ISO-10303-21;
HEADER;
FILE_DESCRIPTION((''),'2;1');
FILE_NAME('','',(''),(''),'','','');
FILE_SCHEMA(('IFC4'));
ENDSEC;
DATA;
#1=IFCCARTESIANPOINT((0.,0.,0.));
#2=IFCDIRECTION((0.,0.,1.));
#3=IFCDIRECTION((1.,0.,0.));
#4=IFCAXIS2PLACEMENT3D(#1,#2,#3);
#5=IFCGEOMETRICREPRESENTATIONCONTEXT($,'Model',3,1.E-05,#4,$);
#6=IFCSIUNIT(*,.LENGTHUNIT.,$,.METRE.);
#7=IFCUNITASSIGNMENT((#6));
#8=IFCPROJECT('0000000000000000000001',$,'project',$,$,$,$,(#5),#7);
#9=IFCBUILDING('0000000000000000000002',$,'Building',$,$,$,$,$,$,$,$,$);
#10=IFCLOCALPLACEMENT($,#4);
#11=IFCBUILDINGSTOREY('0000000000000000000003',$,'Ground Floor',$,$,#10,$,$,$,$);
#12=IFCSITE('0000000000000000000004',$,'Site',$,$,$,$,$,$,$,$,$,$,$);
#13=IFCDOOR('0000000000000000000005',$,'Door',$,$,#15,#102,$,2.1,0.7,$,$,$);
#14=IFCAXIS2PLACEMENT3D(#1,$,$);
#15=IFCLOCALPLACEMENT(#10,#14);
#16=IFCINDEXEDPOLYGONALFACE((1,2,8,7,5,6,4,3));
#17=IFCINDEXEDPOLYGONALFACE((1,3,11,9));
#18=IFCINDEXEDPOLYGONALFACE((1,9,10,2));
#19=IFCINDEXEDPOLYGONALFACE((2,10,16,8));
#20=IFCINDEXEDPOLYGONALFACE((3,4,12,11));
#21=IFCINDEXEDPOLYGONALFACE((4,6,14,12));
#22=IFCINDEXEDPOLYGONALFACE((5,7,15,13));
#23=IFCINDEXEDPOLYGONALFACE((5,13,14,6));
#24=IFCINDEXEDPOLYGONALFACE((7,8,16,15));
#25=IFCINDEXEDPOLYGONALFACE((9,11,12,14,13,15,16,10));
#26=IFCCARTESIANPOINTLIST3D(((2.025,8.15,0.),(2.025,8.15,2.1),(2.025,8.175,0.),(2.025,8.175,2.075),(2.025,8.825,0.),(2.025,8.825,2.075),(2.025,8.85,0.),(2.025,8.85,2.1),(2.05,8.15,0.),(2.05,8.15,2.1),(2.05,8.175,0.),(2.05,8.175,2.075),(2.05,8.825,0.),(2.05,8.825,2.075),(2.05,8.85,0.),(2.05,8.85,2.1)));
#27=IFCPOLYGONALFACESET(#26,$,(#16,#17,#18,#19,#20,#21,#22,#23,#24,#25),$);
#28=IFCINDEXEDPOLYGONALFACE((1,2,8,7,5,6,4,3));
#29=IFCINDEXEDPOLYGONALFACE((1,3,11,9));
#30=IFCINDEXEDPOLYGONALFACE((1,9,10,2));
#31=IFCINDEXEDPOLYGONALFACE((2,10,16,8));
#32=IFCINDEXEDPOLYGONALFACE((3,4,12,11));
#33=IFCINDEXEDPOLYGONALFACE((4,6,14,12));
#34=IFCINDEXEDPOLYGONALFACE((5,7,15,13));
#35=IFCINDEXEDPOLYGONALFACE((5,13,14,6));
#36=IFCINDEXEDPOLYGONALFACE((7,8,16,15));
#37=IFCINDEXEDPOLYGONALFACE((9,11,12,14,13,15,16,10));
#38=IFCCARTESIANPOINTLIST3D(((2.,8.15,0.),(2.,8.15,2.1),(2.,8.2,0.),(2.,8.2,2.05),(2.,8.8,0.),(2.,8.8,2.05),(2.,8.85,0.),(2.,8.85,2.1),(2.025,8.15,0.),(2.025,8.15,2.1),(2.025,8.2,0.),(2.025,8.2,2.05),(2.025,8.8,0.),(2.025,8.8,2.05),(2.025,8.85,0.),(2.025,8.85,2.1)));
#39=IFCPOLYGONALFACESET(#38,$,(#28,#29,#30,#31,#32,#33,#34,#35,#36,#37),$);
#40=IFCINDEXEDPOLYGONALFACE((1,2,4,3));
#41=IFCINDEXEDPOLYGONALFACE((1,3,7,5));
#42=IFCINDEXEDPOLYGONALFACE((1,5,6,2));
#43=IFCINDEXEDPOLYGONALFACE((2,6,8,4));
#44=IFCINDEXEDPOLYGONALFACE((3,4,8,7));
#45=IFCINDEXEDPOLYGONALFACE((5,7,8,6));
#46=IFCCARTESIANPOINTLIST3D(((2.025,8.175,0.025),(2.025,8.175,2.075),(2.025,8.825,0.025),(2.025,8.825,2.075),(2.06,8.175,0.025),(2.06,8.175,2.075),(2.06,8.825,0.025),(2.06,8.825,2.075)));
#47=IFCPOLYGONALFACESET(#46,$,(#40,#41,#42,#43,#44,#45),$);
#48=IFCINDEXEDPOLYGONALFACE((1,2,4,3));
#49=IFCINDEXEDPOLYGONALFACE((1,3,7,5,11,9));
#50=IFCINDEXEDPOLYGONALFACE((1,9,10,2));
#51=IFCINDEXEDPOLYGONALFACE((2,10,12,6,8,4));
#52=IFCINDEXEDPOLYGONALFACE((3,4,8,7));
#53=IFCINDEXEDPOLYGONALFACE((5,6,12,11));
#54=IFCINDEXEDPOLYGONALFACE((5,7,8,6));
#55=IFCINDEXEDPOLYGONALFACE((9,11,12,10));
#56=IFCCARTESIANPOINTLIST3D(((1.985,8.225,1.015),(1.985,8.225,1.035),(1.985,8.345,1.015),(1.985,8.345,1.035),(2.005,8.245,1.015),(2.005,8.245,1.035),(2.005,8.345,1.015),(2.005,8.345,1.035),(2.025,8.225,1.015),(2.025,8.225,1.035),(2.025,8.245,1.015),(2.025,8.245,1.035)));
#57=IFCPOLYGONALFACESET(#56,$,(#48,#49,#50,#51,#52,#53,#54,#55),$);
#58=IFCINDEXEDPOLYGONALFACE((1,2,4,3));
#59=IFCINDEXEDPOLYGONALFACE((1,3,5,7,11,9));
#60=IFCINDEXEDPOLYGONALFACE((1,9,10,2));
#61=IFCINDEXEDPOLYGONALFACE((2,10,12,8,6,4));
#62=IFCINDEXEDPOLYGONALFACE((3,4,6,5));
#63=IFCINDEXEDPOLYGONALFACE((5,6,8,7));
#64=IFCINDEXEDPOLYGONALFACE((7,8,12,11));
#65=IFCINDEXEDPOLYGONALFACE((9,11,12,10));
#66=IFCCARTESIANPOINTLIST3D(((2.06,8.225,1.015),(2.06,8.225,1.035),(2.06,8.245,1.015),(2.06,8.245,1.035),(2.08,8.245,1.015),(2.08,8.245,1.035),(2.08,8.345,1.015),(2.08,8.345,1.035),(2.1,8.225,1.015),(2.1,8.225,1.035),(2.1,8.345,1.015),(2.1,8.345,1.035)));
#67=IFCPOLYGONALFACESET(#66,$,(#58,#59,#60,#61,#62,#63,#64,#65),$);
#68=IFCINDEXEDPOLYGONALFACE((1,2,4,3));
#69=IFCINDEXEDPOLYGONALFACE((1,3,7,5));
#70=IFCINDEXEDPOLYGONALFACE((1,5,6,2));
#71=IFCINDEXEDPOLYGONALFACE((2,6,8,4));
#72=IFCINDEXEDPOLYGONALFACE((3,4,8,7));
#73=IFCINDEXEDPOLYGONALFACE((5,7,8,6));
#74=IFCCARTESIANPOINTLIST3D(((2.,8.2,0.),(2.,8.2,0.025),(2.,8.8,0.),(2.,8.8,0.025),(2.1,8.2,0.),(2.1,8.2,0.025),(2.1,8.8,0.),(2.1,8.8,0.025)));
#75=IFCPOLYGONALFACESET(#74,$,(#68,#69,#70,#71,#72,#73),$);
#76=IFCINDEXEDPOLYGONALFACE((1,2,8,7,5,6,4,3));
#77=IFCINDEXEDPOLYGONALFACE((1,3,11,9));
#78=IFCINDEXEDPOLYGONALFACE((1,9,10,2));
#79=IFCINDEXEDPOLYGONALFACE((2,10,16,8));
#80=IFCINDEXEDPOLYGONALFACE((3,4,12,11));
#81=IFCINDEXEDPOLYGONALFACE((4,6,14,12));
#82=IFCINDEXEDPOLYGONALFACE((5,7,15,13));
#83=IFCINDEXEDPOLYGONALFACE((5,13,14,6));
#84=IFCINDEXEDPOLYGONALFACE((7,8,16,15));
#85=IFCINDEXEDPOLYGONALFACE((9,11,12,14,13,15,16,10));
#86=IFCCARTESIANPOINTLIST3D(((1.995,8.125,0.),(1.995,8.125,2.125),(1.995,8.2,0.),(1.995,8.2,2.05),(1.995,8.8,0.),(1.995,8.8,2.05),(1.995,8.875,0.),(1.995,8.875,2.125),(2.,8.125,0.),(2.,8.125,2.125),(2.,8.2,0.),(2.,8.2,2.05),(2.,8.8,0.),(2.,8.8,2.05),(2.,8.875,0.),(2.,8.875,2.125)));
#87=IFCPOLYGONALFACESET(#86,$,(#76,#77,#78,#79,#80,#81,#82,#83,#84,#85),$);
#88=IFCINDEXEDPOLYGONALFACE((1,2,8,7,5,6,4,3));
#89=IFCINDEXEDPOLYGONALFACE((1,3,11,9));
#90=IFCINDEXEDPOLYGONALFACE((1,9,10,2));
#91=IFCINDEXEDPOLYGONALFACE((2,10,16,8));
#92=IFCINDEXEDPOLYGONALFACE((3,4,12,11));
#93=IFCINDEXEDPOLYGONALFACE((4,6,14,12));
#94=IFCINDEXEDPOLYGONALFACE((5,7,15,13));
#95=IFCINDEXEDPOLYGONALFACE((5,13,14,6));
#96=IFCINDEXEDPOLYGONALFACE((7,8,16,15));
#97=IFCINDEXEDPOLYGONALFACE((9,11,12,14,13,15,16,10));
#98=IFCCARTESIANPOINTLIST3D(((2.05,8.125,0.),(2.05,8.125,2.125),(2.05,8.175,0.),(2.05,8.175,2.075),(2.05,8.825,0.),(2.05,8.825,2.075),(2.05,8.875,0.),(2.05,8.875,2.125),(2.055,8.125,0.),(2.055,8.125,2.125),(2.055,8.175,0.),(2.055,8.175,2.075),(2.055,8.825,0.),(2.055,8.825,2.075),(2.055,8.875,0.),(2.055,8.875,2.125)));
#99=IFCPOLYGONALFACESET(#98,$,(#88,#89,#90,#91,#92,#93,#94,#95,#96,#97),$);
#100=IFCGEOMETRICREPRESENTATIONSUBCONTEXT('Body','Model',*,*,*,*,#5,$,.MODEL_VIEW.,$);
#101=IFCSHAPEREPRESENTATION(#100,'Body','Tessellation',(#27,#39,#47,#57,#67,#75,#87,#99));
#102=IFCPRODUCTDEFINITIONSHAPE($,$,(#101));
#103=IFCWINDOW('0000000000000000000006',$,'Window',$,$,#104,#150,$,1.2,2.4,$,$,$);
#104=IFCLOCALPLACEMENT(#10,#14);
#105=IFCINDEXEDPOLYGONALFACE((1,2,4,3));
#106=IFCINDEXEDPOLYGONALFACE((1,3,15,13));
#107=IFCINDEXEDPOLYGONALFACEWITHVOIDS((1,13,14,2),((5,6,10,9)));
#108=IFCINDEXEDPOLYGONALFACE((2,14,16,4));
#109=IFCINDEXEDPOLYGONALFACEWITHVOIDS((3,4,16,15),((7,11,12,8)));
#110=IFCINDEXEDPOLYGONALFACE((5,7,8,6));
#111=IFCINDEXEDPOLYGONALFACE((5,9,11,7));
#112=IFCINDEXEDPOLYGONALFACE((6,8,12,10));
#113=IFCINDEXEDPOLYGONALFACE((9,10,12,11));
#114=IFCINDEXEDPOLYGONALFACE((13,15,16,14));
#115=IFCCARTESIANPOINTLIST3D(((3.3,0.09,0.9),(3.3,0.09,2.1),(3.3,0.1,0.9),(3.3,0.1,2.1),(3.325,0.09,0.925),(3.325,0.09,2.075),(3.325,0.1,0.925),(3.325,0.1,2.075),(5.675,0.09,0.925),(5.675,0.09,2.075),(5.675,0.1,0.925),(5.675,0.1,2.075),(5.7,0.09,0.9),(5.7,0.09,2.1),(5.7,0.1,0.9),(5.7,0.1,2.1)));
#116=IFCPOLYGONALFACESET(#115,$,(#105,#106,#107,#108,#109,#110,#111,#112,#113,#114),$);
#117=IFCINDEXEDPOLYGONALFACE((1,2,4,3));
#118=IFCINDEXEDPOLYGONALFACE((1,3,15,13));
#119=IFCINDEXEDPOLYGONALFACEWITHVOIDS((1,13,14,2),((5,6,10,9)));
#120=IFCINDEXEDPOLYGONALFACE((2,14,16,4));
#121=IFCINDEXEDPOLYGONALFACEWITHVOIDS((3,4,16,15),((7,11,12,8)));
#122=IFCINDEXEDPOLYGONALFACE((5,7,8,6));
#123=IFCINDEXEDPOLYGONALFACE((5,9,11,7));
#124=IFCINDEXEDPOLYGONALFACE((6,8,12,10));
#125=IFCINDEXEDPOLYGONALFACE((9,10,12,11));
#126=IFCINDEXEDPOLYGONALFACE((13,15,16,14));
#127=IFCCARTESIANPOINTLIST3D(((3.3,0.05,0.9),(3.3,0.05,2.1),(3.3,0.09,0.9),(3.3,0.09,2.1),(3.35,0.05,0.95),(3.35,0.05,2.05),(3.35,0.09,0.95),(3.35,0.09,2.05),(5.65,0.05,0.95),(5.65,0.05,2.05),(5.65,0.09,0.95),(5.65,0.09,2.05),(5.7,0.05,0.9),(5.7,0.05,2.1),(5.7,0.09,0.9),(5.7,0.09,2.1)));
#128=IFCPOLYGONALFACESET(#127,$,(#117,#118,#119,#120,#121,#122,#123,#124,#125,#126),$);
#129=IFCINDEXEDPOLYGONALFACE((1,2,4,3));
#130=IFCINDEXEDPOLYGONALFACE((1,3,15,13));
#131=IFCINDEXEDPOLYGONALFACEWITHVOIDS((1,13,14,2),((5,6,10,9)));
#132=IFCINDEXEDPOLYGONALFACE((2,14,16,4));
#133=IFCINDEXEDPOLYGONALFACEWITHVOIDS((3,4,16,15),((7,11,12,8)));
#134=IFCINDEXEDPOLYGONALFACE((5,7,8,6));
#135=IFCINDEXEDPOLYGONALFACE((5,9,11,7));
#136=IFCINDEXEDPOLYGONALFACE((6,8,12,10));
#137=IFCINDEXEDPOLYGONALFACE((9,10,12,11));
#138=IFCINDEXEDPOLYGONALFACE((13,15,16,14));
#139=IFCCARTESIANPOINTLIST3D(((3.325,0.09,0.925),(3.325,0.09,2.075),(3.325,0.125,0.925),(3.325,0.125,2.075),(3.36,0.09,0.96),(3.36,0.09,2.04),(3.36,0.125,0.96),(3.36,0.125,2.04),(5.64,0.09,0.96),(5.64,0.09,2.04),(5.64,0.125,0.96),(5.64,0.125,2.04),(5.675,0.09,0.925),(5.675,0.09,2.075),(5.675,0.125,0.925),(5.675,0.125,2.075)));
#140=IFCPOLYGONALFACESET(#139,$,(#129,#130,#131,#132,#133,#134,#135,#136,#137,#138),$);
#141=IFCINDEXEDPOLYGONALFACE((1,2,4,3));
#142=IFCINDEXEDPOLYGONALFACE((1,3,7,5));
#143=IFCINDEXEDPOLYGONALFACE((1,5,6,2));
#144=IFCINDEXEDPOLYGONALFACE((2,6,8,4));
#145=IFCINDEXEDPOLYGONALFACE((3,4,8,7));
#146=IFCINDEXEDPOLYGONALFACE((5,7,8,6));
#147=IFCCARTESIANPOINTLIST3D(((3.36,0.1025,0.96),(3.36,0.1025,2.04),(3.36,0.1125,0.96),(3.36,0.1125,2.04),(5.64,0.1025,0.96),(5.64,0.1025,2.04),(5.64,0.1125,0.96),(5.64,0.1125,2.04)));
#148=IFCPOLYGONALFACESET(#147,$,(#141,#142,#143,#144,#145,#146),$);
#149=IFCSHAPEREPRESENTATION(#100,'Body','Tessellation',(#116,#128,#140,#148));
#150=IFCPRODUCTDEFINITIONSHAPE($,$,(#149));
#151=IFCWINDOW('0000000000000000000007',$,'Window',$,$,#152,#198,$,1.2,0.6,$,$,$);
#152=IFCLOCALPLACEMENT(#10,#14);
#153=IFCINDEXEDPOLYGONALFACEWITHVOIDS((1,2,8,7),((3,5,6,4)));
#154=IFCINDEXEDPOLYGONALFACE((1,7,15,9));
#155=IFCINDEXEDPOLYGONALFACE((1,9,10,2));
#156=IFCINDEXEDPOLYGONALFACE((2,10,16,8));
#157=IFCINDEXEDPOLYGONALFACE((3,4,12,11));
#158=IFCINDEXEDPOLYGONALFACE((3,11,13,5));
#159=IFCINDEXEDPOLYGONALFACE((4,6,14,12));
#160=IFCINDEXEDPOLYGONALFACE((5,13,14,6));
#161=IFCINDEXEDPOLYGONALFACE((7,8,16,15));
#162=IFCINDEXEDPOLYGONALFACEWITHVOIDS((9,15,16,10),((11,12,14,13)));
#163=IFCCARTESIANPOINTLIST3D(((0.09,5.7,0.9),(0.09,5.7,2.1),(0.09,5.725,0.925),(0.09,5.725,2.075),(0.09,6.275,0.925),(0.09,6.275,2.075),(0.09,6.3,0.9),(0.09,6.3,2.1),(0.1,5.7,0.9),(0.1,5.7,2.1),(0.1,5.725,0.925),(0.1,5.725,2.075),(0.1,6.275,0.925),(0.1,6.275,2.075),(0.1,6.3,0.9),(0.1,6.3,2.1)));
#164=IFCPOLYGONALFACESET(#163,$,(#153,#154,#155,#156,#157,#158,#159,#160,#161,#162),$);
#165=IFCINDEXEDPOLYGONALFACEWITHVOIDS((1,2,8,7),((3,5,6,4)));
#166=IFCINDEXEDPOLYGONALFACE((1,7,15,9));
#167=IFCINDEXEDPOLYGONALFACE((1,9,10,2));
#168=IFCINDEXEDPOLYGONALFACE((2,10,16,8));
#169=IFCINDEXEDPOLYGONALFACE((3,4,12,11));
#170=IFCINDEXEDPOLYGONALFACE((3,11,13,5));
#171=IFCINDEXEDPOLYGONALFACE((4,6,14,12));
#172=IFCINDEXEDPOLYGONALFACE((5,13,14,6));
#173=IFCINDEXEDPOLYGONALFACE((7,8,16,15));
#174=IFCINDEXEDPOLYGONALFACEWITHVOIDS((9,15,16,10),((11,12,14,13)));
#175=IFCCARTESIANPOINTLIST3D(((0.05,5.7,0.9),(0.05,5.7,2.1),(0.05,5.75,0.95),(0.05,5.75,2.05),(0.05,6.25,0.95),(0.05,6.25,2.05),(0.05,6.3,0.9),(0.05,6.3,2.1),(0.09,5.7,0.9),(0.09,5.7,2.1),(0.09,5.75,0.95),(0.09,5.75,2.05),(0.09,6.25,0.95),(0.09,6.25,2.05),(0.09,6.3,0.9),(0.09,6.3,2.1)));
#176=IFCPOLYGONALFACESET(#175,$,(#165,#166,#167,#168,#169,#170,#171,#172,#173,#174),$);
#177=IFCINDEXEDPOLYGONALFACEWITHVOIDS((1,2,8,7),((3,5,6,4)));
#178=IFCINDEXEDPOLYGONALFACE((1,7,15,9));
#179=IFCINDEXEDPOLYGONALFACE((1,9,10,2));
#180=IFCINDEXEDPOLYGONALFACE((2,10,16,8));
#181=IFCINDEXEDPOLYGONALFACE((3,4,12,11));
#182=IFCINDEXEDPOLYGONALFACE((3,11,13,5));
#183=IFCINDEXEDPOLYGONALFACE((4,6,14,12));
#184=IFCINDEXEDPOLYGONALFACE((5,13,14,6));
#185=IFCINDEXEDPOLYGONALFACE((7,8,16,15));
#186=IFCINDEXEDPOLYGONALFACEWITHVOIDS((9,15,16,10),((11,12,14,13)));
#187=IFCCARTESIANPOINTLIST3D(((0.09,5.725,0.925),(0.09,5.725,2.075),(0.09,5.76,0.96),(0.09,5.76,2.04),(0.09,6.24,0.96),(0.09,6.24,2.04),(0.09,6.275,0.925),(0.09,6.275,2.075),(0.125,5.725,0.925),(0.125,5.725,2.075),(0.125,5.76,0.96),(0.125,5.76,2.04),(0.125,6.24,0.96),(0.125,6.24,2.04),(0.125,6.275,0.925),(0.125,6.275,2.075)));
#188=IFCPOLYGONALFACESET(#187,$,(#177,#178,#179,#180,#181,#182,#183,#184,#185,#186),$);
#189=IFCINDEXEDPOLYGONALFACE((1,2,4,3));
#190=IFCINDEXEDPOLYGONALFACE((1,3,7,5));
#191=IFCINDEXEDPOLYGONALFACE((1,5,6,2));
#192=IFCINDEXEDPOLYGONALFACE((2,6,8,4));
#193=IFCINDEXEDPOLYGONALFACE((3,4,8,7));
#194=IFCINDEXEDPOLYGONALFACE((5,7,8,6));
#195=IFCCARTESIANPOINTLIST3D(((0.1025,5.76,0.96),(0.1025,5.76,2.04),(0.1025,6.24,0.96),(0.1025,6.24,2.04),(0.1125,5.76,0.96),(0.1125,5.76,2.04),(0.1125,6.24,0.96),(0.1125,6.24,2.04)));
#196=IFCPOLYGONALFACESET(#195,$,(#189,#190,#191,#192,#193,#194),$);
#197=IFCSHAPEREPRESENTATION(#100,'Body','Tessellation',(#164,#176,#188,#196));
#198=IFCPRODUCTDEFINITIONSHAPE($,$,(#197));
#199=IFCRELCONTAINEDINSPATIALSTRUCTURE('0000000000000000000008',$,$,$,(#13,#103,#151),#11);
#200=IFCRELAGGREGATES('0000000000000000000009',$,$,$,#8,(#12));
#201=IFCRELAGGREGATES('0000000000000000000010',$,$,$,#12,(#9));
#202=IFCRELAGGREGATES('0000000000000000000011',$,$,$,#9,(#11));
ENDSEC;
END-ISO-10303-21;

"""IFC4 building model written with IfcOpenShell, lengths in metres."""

from ifc_helpers import new_model, si_unit, frame, origin_with_axes, place, context, subcontext, project, spatial, line, indexed_curve, outline, extrude, element, save


model = new_model("IFC4")

# Units and contexts
model_context = context("Model", 3, precision=1e-05, world=origin_with_axes())
body_context = subcontext(model_context, "Body", "Model", "MODEL_VIEW")
ifc_project = project(units=[si_unit("LENGTHUNIT", "METRE")], contexts=[model_context])

# Site, building, storey
site = spatial("IfcSite", under=ifc_project, Name="Site")
building = spatial("IfcBuilding", under=site, Name="Building")
storey_placement = place(None, origin_with_axes())
storey = spatial("IfcBuildingStorey", under=building, at=storey_placement, Name="Ground Floor")

# Door
door_1_placement = place(storey_placement, frame((2.0, 8.85, 0.0), z_axis=(0.0, 0.0, 1.0), x_axis=(0.0, -1.0, 0.0)))
element("IfcDoor", 1, at=door_1_placement, inside=storey, Name="Door", OverallHeight=2.1, OverallWidth=0.7, context=body_context, shape_type="SweptSolid", body=[
    extrude(outline(indexed_curve([(0.0, 0.0), (0.0, 2.1), (0.7, 2.1), (0.7, 0.0), (0.675, 0.0), (0.675, 2.075), (0.025, 2.075), (0.025, 0.0)], segments=[line(1, 2, 3, 4, 5, 6, 7, 8, 1)])), frame((0.0, 0.025, 0.0), z_axis=(0.0, -1.0, 0.0), x_axis=(1.0, 0.0, 0.0)), (0.0, 0.0, -1.0), 0.025),
    extrude(outline(indexed_curve([(0.0, 0.0), (0.0, 2.1), (0.7, 2.1), (0.7, 0.0), (0.65, 0.0), (0.65, 2.05), (0.05, 2.05), (0.05, 0.0)], segments=[line(1, 2, 3, 4, 5, 6, 7, 8, 1)])), frame((0.0, 0.0, 0.0), z_axis=(0.0, -1.0, 0.0), x_axis=(1.0, 0.0, 0.0)), (0.0, 0.0, -1.0), 0.025),
    extrude(outline(indexed_curve([(0.0, 0.0), (0.65, 0.0), (0.65, 0.035), (0.0, 0.035)], segments=[line(1, 2, 3, 4, 1)])), frame((0.025, 0.025, 0.025), z_axis=(0.0, 0.0, 1.0), x_axis=(1.0, 0.0, 0.0)), (0.0, 0.0, 1.0), 2.05),
    extrude(outline(indexed_curve([(0.0, 0.0), (0.0, -0.04), (-0.12, -0.04), (-0.12, -0.02), (-0.02, -0.02), (-0.02, 0.0)], segments=[line(1, 2, 3, 4, 5, 6, 1)])), frame((0.625, 0.025, 1.015), z_axis=(0.0, 0.0, 1.0), x_axis=(1.0, 0.0, 0.0)), (0.0, 0.0, 1.0), 0.02),
    extrude(outline(indexed_curve([(0.0, 0.0), (0.0, 0.04), (-0.12, 0.04), (-0.12, 0.02), (-0.02, 0.02), (-0.02, 0.0)], segments=[line(1, 2, 3, 4, 5, 6, 1)])), frame((0.625, 0.06, 1.015), z_axis=(0.0, 0.0, 1.0), x_axis=(1.0, 0.0, 0.0)), (0.0, 0.0, 1.0), 0.02),
    extrude(outline(indexed_curve([(0.0, 0.0), (0.6, 0.0), (0.6, 0.1), (0.0, 0.1)], segments=[line(1, 2, 3, 4, 1)])), frame((0.05, 0.0, 0.0), z_axis=(0.0, 0.0, 1.0), x_axis=(1.0, 0.0, 0.0)), (0.0, 0.0, 1.0), 0.025),
    extrude(outline(indexed_curve([(0.0, 0.0), (0.0, 2.125), (0.75, 2.125), (0.75, 0.0), (0.675, 0.0), (0.675, 2.05), (0.075, 2.05), (0.075, 0.0)], segments=[line(1, 2, 3, 4, 5, 6, 7, 8, 1)])), frame((-0.025, -0.005, 0.0), z_axis=(0.0, -1.0, 0.0), x_axis=(1.0, 0.0, 0.0)), (0.0, 0.0, -1.0), 0.005),
    extrude(outline(indexed_curve([(0.0, 0.0), (0.0, 2.125), (0.75, 2.125), (0.75, 0.0), (0.7, 0.0), (0.7, 2.075), (0.05, 2.075), (0.05, 0.0)], segments=[line(1, 2, 3, 4, 5, 6, 7, 8, 1)])), frame((-0.025, 0.05, 0.0), z_axis=(0.0, -1.0, 0.0), x_axis=(1.0, 0.0, 0.0)), (0.0, 0.0, -1.0), 0.005),
])

# Windows
window_1_placement = place(storey_placement, frame((3.3, 0.0, 0.9), z_axis=(0.0, 0.0, 1.0), x_axis=(1.0, 0.0, 0.0)))
element("IfcWindow", 2, at=window_1_placement, inside=storey, Name="Window", OverallHeight=1.2, OverallWidth=2.4, context=body_context, shape_type="SweptSolid", body=[
    extrude(outline(indexed_curve([(0.0, 0.0), (2.4, 0.0), (2.4, 1.2), (0.0, 1.2)], segments=[line(1, 2, 3, 4, 1)]), holes=[indexed_curve([(0.025, 0.025), (2.375, 0.025), (2.375, 1.175), (0.025, 1.175)], segments=[line(1, 2, 3, 4, 1)])]), frame((0.0, 0.09, 0.0), z_axis=(0.0, -1.0, 0.0), x_axis=(1.0, 0.0, 0.0)), (0.0, 0.0, -1.0), 0.01),
    extrude(outline(indexed_curve([(0.0, 0.0), (2.4, 0.0), (2.4, 1.2), (0.0, 1.2)], segments=[line(1, 2, 3, 4, 1)]), holes=[indexed_curve([(0.05, 0.05), (2.35, 0.05), (2.35, 1.15), (0.05, 1.15)], segments=[line(1, 2, 3, 4, 1)])]), frame((0.0, 0.05, 0.0), z_axis=(0.0, -1.0, 0.0), x_axis=(1.0, 0.0, 0.0)), (0.0, 0.0, -1.0), 0.04),
    extrude(outline(indexed_curve([(0.0, 0.0), (2.35, 0.0), (2.35, 1.15), (0.0, 1.15)], segments=[line(1, 2, 3, 4, 1)]), holes=[indexed_curve([(0.035, 0.035), (2.315, 0.035), (2.315, 1.115), (0.035, 1.115)], segments=[line(1, 2, 3, 4, 1)])]), frame((0.025, 0.09, 0.025), z_axis=(0.0, -1.0, 0.0), x_axis=(1.0, 0.0, 0.0)), (0.0, 0.0, -1.0), 0.035),
    extrude(outline(indexed_curve([(0.035, 0.035), (2.315, 0.035), (2.315, 1.115), (0.035, 1.115)], segments=[line(1, 2, 3, 4, 1)])), frame((0.025, 0.1025, 0.025), z_axis=(0.0, -1.0, 0.0), x_axis=(1.0, 0.0, 0.0)), (0.0, 0.0, -1.0), 0.01),
])
window_2_placement = place(storey_placement, frame((0.0, 6.3, 0.9), z_axis=(0.0, 0.0, 1.0), x_axis=(0.0, -1.0, 0.0)))
element("IfcWindow", 3, at=window_2_placement, inside=storey, Name="Window", OverallHeight=1.2, OverallWidth=0.6, context=body_context, shape_type="SweptSolid", body=[
    extrude(outline(indexed_curve([(0.0, 0.0), (0.6, 0.0), (0.6, 1.2), (0.0, 1.2)], segments=[line(1, 2, 3, 4, 1)]), holes=[indexed_curve([(0.025, 0.025), (0.575, 0.025), (0.575, 1.175), (0.025, 1.175)], segments=[line(1, 2, 3, 4, 1)])]), frame((0.0, 0.09, 0.0), z_axis=(0.0, -1.0, 0.0), x_axis=(1.0, 0.0, 0.0)), (0.0, 0.0, -1.0), 0.01),
    extrude(outline(indexed_curve([(0.0, 0.0), (0.6, 0.0), (0.6, 1.2), (0.0, 1.2)], segments=[line(1, 2, 3, 4, 1)]), holes=[indexed_curve([(0.05, 0.05), (0.55, 0.05), (0.55, 1.15), (0.05, 1.15)], segments=[line(1, 2, 3, 4, 1)])]), frame((0.0, 0.05, 0.0), z_axis=(0.0, -1.0, 0.0), x_axis=(1.0, 0.0, 0.0)), (0.0, 0.0, -1.0), 0.04),
    extrude(outline(indexed_curve([(0.0, 0.0), (0.55, 0.0), (0.55, 1.15), (0.0, 1.15)], segments=[line(1, 2, 3, 4, 1)]), holes=[indexed_curve([(0.035, 0.035), (0.515, 0.035), (0.515, 1.115), (0.035, 1.115)], segments=[line(1, 2, 3, 4, 1)])]), frame((0.025, 0.09, 0.025), z_axis=(0.0, -1.0, 0.0), x_axis=(1.0, 0.0, 0.0)), (0.0, 0.0, -1.0), 0.035),
    extrude(outline(indexed_curve([(0.035, 0.035), (0.515, 0.035), (0.515, 1.115), (0.035, 1.115)], segments=[line(1, 2, 3, 4, 1)])), frame((0.025, 0.1025, 0.025), z_axis=(0.0, -1.0, 0.0), x_axis=(1.0, 0.0, 0.0)), (0.0, 0.0, -1.0), 0.01),
])

save(model, "model.ifc")
